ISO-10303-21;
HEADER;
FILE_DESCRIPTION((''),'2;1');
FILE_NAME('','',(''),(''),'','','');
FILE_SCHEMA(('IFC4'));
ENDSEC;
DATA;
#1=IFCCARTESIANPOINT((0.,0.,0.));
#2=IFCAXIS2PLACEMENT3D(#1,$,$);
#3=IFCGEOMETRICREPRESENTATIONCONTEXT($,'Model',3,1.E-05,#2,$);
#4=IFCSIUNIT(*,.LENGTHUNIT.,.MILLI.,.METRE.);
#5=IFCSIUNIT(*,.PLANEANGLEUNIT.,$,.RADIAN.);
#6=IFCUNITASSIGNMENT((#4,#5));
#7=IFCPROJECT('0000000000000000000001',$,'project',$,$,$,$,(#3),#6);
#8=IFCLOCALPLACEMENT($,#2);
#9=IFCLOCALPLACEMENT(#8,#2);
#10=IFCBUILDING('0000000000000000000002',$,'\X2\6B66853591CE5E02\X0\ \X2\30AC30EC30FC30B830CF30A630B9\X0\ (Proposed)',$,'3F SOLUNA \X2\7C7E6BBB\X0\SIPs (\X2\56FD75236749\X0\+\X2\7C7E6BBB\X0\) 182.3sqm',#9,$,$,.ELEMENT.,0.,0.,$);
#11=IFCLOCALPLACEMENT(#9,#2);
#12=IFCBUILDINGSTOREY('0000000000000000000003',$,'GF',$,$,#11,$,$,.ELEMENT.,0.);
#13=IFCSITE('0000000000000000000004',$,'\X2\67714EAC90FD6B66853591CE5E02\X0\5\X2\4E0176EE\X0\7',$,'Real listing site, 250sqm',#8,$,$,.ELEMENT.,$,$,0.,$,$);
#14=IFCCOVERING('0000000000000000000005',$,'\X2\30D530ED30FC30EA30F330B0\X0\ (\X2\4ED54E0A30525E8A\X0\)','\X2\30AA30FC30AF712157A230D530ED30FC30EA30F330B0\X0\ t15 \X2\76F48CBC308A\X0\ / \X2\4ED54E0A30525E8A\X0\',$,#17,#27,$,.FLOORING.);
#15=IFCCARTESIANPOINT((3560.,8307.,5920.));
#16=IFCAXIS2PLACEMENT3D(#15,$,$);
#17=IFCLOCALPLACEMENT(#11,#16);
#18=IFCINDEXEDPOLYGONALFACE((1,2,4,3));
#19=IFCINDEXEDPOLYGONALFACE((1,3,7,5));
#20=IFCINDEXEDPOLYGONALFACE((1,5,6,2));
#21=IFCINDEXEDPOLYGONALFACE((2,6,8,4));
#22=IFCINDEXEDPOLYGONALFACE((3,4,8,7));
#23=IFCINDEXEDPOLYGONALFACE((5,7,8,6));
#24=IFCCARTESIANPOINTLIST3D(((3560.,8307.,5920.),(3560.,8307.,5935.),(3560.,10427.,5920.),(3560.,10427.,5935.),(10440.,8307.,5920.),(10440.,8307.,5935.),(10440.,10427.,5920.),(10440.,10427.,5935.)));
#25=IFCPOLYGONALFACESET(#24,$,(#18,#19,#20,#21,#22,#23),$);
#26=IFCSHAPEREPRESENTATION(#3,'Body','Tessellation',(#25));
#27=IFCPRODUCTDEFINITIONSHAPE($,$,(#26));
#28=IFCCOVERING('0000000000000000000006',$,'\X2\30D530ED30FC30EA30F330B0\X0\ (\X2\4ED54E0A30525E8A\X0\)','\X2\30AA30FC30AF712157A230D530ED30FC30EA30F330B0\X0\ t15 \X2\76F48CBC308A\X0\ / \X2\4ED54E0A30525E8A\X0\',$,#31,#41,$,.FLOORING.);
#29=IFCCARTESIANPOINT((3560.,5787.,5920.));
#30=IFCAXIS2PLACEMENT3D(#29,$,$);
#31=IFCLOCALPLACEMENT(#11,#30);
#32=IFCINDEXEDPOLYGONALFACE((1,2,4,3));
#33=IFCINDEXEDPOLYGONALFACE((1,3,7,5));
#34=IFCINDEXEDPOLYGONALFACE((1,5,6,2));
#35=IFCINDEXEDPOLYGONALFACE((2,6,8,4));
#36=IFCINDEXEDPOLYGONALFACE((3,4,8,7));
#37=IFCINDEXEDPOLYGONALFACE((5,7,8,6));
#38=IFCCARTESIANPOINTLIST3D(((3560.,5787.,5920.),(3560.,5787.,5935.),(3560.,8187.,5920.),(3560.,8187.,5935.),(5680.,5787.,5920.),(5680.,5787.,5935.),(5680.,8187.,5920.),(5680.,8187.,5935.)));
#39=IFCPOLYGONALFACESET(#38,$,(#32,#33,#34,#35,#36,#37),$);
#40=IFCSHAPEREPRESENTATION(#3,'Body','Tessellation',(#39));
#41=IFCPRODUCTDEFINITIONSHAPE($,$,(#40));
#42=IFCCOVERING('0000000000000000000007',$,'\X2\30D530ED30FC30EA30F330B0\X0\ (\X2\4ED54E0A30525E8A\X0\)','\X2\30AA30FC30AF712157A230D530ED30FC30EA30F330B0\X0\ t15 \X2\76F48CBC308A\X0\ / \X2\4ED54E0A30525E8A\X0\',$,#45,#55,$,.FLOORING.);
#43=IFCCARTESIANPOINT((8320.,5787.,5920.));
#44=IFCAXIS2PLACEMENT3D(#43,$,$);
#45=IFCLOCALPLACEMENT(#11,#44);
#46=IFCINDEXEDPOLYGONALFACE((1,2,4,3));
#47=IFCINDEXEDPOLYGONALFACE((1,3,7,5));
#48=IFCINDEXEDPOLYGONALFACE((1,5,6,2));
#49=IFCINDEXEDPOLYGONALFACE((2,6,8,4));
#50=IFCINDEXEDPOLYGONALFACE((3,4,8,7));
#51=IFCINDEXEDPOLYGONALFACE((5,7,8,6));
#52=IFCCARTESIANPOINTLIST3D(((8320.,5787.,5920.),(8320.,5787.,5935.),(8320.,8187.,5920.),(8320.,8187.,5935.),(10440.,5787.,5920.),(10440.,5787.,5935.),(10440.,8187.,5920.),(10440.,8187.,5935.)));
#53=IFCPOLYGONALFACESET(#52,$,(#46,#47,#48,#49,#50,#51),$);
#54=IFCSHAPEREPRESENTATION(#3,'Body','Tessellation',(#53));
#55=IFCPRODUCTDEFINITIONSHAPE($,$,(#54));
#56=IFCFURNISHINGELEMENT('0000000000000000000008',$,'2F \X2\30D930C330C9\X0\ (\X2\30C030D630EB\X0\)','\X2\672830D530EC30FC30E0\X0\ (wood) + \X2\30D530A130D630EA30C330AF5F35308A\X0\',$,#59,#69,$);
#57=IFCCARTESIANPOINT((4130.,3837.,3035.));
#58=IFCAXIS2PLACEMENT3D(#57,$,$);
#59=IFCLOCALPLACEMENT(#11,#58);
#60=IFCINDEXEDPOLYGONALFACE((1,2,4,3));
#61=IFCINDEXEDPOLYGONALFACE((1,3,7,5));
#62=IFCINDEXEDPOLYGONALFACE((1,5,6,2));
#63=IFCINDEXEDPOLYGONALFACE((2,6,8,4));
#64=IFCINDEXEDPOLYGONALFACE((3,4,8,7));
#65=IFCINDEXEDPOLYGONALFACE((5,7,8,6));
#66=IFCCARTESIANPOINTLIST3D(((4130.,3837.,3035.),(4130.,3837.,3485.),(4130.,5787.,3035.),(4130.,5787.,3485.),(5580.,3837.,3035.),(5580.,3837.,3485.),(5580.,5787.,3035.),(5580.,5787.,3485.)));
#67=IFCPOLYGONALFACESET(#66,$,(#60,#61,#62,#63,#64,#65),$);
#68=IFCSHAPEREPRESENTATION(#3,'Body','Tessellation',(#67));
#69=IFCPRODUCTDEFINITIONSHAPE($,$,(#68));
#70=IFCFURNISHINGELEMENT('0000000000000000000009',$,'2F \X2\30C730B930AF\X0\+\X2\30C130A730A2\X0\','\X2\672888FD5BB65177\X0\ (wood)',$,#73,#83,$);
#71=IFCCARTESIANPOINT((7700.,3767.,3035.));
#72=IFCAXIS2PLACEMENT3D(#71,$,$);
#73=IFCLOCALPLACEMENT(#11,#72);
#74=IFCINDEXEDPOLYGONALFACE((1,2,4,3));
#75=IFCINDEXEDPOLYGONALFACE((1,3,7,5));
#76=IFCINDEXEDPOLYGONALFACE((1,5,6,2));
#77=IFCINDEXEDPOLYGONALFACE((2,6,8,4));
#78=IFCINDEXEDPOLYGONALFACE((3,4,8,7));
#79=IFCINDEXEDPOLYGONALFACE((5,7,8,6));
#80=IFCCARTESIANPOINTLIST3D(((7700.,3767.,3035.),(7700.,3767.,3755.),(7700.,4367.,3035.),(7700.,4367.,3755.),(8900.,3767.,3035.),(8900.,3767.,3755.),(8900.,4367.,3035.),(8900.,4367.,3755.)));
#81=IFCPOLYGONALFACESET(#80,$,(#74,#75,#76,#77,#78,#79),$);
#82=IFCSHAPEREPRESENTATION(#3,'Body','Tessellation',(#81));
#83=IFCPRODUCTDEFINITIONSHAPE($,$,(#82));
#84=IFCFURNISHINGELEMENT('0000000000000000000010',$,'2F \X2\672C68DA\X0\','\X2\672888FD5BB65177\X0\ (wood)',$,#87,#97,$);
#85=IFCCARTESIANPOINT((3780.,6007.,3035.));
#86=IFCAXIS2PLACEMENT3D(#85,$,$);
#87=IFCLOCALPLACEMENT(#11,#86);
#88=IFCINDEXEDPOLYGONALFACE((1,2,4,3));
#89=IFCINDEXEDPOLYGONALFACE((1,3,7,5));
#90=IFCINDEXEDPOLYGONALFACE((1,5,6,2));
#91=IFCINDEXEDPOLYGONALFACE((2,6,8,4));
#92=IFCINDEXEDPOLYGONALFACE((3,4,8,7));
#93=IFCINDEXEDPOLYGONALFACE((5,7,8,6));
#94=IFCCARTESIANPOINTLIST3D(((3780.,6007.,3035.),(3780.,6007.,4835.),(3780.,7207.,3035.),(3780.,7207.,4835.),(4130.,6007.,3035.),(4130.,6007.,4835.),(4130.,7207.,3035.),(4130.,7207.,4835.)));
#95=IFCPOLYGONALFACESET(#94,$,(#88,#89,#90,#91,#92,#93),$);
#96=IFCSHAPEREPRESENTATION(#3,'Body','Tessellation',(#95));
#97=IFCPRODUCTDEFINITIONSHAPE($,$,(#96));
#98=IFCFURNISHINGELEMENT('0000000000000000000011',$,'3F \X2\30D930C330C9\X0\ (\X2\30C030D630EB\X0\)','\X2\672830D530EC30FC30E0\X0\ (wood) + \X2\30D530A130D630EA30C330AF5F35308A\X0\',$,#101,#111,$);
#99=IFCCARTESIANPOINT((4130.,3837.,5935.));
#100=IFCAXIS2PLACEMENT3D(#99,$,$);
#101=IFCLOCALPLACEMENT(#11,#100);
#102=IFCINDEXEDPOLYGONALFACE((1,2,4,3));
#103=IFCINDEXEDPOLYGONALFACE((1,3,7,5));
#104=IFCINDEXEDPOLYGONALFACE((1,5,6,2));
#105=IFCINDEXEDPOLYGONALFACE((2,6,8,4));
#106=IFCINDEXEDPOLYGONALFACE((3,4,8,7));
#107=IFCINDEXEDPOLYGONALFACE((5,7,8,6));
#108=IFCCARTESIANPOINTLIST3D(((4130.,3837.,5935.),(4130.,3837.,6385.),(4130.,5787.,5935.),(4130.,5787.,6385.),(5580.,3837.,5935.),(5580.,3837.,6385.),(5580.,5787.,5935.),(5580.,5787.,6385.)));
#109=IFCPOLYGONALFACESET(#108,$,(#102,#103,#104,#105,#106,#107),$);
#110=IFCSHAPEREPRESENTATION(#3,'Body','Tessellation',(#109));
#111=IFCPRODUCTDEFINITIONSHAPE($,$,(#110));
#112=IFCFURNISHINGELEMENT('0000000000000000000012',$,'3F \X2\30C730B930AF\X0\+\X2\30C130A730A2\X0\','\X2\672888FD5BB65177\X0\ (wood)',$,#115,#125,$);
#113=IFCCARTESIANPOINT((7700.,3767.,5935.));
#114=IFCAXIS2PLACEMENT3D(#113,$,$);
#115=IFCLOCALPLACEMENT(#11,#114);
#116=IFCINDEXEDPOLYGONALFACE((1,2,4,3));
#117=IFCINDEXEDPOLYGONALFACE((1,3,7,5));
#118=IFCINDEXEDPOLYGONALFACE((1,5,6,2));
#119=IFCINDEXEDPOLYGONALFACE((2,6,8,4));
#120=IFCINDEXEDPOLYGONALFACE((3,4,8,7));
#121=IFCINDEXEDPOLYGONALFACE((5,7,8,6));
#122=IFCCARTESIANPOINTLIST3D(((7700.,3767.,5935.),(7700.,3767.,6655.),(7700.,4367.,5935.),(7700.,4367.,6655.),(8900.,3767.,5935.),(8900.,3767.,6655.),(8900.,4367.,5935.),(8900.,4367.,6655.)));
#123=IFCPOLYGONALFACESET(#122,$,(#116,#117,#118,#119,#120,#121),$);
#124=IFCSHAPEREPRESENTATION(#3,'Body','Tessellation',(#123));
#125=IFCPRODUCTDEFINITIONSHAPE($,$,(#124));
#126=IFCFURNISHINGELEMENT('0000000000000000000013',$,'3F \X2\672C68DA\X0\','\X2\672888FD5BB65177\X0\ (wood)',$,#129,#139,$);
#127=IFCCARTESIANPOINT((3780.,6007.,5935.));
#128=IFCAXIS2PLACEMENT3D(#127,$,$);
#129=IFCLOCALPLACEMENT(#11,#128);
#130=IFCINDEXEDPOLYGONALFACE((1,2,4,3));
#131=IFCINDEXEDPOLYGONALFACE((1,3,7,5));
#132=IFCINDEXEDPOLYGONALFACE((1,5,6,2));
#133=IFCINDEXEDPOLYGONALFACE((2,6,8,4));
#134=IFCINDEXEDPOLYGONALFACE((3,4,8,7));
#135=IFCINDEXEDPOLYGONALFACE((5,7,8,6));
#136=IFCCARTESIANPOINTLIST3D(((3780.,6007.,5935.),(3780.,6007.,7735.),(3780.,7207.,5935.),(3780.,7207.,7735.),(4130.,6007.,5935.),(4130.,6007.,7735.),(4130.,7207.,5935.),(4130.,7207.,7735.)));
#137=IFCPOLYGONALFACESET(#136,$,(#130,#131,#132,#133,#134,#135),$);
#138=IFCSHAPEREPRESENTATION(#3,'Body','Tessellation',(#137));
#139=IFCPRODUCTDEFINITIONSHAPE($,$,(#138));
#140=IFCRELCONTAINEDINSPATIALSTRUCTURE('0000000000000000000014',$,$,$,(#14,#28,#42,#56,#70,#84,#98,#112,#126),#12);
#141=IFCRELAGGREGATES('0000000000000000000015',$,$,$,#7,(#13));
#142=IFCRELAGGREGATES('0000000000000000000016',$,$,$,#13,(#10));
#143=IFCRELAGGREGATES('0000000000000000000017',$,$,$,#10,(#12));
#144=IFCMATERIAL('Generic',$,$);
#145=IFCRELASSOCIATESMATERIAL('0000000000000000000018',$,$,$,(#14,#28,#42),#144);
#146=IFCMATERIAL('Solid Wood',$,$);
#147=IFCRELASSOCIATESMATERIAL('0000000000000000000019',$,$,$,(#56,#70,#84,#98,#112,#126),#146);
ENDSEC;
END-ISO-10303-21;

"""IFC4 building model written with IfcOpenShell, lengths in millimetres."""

from ifc_helpers import new_model, si_unit, frame, frame_2d, origin, place, context, project, spatial, rectangle, extrude, material, element, save


model = new_model("IFC4")

# Units and contexts
model_context = context("Model", 3, precision=1e-05, world=origin())
ifc_project = project(units=[si_unit("LENGTHUNIT", "METRE", prefix="MILLI"), si_unit("PLANEANGLEUNIT", "RADIAN")], contexts=[model_context])

# Site, building, storey
site_placement = place(None, origin())
site = spatial("IfcSite", under=ifc_project, at=site_placement, Name="東京都武蔵野市5丁目7", ObjectType="Real listing site, 250sqm", CompositionType="ELEMENT", RefElevation=0.0)
building_placement = place(site_placement, origin())
building = spatial("IfcBuilding", under=site, at=building_placement, Name="武蔵野市 ガレージハウス (Proposed)", ObjectType="3F SOLUNA 籾殻SIPs (国産杉+籾殻) 182.3sqm", CompositionType="ELEMENT", ElevationOfRefHeight=0.0, ElevationOfTerrain=0.0)
storey_placement = place(building_placement, origin())
storey = spatial("IfcBuildingStorey", under=building, at=storey_placement, Name="GF", CompositionType="ELEMENT", Elevation=0.0)

# Shared definitions
ifc_material_1 = material(Name="Solid Wood")

# Shared definitions
ifc_material_2 = material(Name="Generic")

# Coverings
covering_1_placement = place(storey_placement, frame((3560.0, 8307.0, 5920.0)))
element("IfcCovering", 1, at=covering_1_placement, inside=storey, material=ifc_material_2, Name="フローリング (仕上げ床)", Description="オーク無垢フローリング t15 直貼り / 仕上げ床", PredefinedType="FLOORING", context=model_context, shape_type="SweptSolid", body=[
    extrude(rectangle(XDim=6880.0, YDim=2120.0, at=frame_2d((3440.0, 1060.0))), frame((3560.0, 8307.0, 5920.0)), (0.0, 0.0, 1.0), 15.0),
])
covering_2_placement = place(storey_placement, frame((3560.0, 5787.0, 5920.0)))
element("IfcCovering", 2, at=covering_2_placement, inside=storey, material=ifc_material_2, Name="フローリング (仕上げ床)", Description="オーク無垢フローリング t15 直貼り / 仕上げ床", PredefinedType="FLOORING", context=model_context, shape_type="SweptSolid", body=[
    extrude(rectangle(XDim=2120.0, YDim=2400.0, at=frame_2d((1060.0, 1200.0))), frame((3560.0, 5787.0, 5920.0)), (0.0, 0.0, 1.0), 15.0),
])
covering_3_placement = place(storey_placement, frame((8320.0, 5787.0, 5920.0)))
element("IfcCovering", 3, at=covering_3_placement, inside=storey, material=ifc_material_2, Name="フローリング (仕上げ床)", Description="オーク無垢フローリング t15 直貼り / 仕上げ床", PredefinedType="FLOORING", context=model_context, shape_type="SweptSolid", body=[
    extrude(rectangle(XDim=2120.0, YDim=2400.0, at=frame_2d((1060.0, 1200.0))), frame((8320.0, 5787.0, 5920.0)), (0.0, 0.0, 1.0), 15.0),
])

# Furnishing elements
furnishing_1_placement = place(storey_placement, frame((4130.0, 3837.0, 3035.0)))
element("IfcFurnishingElement", 4, at=furnishing_1_placement, inside=storey, material=ifc_material_1, Name="2F ベッド (ダブル)", Description="木フレーム (wood) + ファブリック張り", context=model_context, shape_type="SweptSolid", body=[
    extrude(rectangle(XDim=1450.0, YDim=1950.0, at=frame_2d((725.0, 975.0))), frame((4130.0, 3837.0, 3035.0)), (0.0, 0.0, 1.0), 450.0),
])
furnishing_2_placement = place(storey_placement, frame((7700.0, 3767.0, 3035.0)))
element("IfcFurnishingElement", 5, at=furnishing_2_placement, inside=storey, material=ifc_material_1, Name="2F デスク+チェア", Description="木製家具 (wood)", context=model_context, shape_type="SweptSolid", body=[
    extrude(rectangle(XDim=1200.0, YDim=600.0, at=frame_2d((600.0, 300.0))), frame((7700.0, 3767.0, 3035.0)), (0.0, 0.0, 1.0), 720.0),
])
furnishing_3_placement = place(storey_placement, frame((3780.0, 6007.0, 3035.0)))
element("IfcFurnishingElement", 6, at=furnishing_3_placement, inside=storey, material=ifc_material_1, Name="2F 本棚", Description="木製家具 (wood)", context=model_context, shape_type="SweptSolid", body=[
    extrude(rectangle(XDim=350.0, YDim=1200.0, at=frame_2d((175.0, 600.0))), frame((3780.0, 6007.0, 3035.0)), (0.0, 0.0, 1.0), 1800.0),
])
furnishing_4_placement = place(storey_placement, frame((4130.0, 3837.0, 5935.0)))
element("IfcFurnishingElement", 7, at=furnishing_4_placement, inside=storey, material=ifc_material_1, Name="3F ベッド (ダブル)", Description="木フレーム (wood) + ファブリック張り", context=model_context, shape_type="SweptSolid", body=[
    extrude(rectangle(XDim=1450.0, YDim=1950.0, at=frame_2d((725.0, 975.0))), frame((4130.0, 3837.0, 5935.0)), (0.0, 0.0, 1.0), 450.0),
])
furnishing_5_placement = place(storey_placement, frame((7700.0, 3767.0, 5935.0)))
element("IfcFurnishingElement", 8, at=furnishing_5_placement, inside=storey, material=ifc_material_1, Name="3F デスク+チェア", Description="木製家具 (wood)", context=model_context, shape_type="SweptSolid", body=[
    extrude(rectangle(XDim=1200.0, YDim=600.0, at=frame_2d((600.0, 300.0))), frame((7700.0, 3767.0, 5935.0)), (0.0, 0.0, 1.0), 720.0),
])
furnishing_6_placement = place(storey_placement, frame((3780.0, 6007.0, 5935.0)))
element("IfcFurnishingElement", 9, at=furnishing_6_placement, inside=storey, material=ifc_material_1, Name="3F 本棚", Description="木製家具 (wood)", context=model_context, shape_type="SweptSolid", body=[
    extrude(rectangle(XDim=350.0, YDim=1200.0, at=frame_2d((175.0, 600.0))), frame((3780.0, 6007.0, 5935.0)), (0.0, 0.0, 1.0), 1800.0),
])

save(model, "model.ifc")
